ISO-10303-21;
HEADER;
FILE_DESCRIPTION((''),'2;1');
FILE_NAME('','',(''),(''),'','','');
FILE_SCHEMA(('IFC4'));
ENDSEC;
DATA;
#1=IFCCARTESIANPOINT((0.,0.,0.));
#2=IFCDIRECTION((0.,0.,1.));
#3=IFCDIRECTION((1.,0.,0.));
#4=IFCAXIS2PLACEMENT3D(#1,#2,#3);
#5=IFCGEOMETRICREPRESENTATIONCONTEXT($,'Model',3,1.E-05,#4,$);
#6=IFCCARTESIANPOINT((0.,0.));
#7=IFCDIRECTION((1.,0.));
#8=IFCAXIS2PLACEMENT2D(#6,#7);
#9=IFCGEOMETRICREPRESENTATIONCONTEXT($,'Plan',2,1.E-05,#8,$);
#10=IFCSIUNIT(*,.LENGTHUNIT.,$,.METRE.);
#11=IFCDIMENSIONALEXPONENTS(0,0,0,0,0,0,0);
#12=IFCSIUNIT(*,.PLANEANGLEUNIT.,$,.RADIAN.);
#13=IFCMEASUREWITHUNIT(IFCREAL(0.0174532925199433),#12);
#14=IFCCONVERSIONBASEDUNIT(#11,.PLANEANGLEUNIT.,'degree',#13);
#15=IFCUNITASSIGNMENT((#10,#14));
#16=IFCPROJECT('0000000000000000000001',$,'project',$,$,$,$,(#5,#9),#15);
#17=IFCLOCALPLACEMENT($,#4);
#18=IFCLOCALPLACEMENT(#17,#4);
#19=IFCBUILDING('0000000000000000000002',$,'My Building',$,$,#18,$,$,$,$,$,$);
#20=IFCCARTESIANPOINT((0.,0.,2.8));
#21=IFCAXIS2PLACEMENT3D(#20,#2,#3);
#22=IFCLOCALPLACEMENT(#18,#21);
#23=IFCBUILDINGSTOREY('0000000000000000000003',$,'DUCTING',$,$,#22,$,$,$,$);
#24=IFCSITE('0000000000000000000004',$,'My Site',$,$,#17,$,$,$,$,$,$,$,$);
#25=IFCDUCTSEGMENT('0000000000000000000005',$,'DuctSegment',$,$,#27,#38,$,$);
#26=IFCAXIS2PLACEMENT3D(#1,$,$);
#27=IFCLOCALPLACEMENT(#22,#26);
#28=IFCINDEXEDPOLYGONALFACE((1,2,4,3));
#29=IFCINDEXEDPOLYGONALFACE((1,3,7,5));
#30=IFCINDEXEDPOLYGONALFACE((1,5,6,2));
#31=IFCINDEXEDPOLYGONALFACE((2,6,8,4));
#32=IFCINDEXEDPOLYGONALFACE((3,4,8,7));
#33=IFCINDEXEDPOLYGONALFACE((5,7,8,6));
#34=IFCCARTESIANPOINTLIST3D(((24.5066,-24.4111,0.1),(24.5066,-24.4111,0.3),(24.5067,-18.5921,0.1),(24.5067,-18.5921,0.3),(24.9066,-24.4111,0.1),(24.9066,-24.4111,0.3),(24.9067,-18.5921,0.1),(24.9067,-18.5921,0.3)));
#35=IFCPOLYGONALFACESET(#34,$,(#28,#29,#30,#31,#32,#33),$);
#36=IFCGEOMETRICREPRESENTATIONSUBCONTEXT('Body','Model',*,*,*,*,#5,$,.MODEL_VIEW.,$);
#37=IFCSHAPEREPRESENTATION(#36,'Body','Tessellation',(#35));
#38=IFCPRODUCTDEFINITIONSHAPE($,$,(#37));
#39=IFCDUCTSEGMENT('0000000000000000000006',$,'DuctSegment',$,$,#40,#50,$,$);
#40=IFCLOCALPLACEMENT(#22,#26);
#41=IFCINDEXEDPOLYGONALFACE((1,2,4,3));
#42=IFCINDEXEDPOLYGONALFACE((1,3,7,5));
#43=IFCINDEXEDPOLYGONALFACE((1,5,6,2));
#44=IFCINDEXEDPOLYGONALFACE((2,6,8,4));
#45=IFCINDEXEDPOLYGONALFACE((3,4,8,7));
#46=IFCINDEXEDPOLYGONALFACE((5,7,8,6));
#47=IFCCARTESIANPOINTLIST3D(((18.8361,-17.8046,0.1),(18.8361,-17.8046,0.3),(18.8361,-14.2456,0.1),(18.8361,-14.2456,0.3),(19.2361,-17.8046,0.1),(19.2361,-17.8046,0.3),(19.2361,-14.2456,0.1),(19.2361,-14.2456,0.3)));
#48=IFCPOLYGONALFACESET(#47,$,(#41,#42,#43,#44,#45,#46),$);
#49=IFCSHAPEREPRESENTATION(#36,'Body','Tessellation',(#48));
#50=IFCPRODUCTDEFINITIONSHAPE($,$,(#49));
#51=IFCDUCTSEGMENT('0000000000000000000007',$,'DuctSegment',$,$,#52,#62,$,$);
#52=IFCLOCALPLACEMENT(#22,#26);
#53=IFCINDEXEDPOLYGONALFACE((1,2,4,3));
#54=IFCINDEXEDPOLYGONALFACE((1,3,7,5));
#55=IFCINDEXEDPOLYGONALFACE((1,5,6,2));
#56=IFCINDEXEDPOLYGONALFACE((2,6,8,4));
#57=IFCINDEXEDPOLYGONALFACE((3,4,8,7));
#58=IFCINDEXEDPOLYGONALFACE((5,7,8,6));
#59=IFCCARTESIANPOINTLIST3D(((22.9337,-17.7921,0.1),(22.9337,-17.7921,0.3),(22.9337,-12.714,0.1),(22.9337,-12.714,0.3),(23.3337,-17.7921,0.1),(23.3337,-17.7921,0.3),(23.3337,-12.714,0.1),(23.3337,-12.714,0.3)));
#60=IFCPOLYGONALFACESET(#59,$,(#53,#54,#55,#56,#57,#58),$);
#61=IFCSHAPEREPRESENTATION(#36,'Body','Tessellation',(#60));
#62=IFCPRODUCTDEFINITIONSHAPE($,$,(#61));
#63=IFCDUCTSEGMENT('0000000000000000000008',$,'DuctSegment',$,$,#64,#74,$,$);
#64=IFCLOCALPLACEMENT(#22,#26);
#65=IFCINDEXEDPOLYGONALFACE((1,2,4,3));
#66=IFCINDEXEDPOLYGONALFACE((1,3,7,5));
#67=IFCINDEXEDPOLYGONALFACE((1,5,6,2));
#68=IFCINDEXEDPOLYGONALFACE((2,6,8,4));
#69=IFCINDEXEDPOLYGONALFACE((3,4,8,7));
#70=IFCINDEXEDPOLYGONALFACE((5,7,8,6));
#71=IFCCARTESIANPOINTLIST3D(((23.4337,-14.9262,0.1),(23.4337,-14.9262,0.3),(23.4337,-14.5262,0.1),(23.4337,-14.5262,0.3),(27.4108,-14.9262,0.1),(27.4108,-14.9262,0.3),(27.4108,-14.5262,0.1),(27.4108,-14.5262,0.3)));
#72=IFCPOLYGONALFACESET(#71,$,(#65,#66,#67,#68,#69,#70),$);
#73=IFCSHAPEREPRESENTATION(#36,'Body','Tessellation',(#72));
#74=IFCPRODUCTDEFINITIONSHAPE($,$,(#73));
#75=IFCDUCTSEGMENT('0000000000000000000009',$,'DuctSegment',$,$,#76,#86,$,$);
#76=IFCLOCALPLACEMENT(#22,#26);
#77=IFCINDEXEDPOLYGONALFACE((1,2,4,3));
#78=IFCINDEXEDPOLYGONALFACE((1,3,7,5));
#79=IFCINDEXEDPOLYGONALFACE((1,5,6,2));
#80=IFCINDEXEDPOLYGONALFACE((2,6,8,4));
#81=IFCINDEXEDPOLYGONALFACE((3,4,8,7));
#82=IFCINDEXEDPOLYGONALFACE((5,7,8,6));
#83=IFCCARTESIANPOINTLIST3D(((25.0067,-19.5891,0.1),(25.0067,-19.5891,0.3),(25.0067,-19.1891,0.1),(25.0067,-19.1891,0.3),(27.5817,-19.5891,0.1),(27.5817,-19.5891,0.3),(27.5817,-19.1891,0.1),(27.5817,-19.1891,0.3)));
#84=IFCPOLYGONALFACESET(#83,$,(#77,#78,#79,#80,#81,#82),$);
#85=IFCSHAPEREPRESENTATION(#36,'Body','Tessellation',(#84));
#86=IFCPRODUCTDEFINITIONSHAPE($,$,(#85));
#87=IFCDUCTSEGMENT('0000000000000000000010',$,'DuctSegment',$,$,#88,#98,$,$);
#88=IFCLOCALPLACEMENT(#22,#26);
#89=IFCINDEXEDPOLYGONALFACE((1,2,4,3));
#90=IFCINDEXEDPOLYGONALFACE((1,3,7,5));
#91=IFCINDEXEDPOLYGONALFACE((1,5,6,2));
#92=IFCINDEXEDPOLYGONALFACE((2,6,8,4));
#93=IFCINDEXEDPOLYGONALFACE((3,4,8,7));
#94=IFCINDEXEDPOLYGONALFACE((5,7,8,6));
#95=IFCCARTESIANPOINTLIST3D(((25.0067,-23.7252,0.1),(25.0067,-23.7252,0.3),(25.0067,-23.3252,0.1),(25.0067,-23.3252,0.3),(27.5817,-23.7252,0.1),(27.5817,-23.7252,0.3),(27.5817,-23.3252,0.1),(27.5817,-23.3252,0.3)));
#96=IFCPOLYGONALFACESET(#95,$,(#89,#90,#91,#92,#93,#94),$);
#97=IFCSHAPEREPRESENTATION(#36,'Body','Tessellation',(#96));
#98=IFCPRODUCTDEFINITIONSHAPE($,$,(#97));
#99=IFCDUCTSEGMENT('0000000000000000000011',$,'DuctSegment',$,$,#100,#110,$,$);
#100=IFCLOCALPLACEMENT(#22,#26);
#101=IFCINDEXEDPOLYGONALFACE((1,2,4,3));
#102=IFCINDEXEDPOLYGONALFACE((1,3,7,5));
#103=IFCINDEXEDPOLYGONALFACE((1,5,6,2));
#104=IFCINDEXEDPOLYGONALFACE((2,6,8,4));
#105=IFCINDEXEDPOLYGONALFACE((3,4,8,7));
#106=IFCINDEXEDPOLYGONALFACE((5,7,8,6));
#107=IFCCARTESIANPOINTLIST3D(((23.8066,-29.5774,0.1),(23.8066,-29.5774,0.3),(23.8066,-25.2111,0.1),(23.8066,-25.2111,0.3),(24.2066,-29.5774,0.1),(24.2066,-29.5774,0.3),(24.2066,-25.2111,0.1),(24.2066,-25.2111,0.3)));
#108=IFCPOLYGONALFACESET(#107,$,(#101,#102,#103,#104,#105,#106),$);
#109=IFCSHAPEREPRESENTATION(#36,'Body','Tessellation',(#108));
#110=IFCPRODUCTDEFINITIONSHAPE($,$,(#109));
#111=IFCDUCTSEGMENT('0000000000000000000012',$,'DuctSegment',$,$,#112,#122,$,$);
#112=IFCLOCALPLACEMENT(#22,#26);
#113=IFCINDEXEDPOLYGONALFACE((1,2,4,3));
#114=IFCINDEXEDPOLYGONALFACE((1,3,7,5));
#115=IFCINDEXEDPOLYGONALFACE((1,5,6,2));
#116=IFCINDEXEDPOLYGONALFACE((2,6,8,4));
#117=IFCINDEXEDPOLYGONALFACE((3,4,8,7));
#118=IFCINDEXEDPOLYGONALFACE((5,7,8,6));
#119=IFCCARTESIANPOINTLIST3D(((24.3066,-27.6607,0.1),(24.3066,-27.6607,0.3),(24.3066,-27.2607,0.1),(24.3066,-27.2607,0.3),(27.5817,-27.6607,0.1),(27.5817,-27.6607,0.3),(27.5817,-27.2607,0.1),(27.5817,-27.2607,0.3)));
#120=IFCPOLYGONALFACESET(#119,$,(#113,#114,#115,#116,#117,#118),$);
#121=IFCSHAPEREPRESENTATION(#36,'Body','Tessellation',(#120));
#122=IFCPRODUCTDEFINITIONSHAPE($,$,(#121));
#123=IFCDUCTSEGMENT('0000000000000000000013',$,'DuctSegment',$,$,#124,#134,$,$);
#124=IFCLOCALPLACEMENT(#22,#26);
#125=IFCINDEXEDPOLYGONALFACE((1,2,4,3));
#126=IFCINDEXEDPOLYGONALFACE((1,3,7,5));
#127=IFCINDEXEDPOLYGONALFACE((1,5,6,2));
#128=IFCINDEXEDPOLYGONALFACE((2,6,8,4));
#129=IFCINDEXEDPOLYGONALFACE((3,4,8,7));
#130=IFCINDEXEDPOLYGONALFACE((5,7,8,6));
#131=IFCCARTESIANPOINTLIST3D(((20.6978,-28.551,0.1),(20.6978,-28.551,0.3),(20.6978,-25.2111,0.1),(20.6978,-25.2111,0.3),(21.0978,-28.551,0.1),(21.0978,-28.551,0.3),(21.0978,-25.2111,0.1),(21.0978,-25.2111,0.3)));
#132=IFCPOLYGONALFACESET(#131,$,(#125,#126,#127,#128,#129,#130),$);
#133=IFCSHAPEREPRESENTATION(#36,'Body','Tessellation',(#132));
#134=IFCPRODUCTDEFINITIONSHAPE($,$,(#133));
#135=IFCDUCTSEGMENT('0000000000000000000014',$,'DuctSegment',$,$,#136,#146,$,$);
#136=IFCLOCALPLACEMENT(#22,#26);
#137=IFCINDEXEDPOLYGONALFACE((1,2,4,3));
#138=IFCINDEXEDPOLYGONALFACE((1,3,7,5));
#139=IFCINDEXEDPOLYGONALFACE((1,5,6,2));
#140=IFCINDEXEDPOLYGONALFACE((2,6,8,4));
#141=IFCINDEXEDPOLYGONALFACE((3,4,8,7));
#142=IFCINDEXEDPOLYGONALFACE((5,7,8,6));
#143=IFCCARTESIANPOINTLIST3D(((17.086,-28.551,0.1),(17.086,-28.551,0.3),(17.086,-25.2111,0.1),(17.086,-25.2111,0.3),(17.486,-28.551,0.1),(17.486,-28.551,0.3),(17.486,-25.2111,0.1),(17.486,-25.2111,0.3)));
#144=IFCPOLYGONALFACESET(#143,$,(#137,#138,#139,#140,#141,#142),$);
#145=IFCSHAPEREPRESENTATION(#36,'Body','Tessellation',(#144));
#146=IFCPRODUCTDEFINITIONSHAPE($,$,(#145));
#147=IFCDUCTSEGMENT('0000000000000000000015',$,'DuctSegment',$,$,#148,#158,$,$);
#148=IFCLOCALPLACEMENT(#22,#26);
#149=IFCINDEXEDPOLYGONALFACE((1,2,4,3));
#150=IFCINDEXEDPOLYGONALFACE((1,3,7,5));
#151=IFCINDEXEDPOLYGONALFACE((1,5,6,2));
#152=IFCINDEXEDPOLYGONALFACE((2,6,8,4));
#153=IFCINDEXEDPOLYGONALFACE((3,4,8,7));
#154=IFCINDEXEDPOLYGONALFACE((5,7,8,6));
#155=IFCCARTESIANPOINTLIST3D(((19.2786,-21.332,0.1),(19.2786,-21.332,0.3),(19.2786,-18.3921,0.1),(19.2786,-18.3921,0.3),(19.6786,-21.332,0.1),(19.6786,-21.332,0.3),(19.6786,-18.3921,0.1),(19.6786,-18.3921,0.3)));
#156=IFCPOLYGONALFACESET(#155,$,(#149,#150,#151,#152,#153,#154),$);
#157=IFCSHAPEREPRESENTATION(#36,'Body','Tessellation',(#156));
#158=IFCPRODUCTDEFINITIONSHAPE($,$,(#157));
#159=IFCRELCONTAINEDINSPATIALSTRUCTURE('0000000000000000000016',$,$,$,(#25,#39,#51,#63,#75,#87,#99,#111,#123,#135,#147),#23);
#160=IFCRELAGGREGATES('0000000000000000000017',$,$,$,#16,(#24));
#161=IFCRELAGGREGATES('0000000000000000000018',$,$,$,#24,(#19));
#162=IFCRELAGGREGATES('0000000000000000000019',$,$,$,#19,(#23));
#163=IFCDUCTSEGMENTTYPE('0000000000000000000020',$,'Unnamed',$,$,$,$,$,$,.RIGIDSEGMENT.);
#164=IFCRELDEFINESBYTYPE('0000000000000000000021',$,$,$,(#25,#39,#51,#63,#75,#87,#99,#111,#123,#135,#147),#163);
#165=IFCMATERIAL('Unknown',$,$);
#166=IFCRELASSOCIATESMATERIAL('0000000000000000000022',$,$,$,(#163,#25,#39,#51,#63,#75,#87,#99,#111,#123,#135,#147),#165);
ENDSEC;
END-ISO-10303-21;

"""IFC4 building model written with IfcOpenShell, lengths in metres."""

from ifc_helpers import new_model, entity, si_unit, converted_unit, frame, origin_with_axes, origin_2d_with_axis, place, context, subcontext, project, spatial, rectangle, extrude, material, material_profile, profile_set, profile_usage, type_object, element, save


model = new_model("IFC4")

# Units and contexts
model_context = context("Model", 3, precision=1e-05, world=origin_with_axes())
plan_context = context("Plan", 2, precision=1e-05, world=origin_2d_with_axis())
body_context = subcontext(model_context, "Body", "Model", "MODEL_VIEW")
ifc_project = project(units=[si_unit("LENGTHUNIT", "METRE"), converted_unit("PLANEANGLEUNIT", "degree", entity("IfcReal", 0.0174532925199433), si_unit("PLANEANGLEUNIT", "RADIAN"), dimensions=[0, 0, 0, 0, 0, 0, 0])], contexts=[model_context, plan_context])

# Site, building, storey
site_placement = place(None, origin_with_axes())
site = spatial("IfcSite", under=ifc_project, at=site_placement, Name="My Site")
building_placement = place(site_placement, origin_with_axes())
building = spatial("IfcBuilding", under=site, at=building_placement, Name="My Building")
storey_placement = place(building_placement, frame((0.0, 0.0, 2.8), z_axis=(0.0, 0.0, 1.0), x_axis=(1.0, 0.0, 0.0)))
storey = spatial("IfcBuildingStorey", under=building, at=storey_placement, Name="DUCTING")

# Duct segments
ifc_material = material(Name="Unknown")
ifc_material_profile_1 = material_profile(ifc_material, rectangle(XDim=0.4, YDim=0.2))
ifc_profile_set_1 = profile_set([ifc_material_profile_1])
ifc_profile_usage_1 = profile_usage(ifc_profile_set_1, cardinal=5)
duct_segment_type = type_object("IfcDuctSegmentType", Name="Unnamed", PredefinedType="RIGIDSEGMENT", material=ifc_profile_set_1)
duct_segment_1_placement = place(storey_placement, frame((24.7067, -18.5921, 0.2), z_axis=(-0.00001, -1.0, 0.000001), x_axis=(1.0, -0.00001, 0.0)))
element("IfcDuctSegment", 1, at=duct_segment_1_placement, inside=storey, type_object=duct_segment_type, material=ifc_profile_usage_1, Name="DuctSegment", context=body_context, shape_type="SweptSolid", body=[
    extrude(rectangle(XDim=0.4, YDim=0.2), origin_with_axes(), (0.0, 0.0, 1.0), 5.819),
])
ifc_profile_usage_2 = profile_usage(ifc_profile_set_1, cardinal=5)
duct_segment_2_placement = place(storey_placement, frame((19.0361, -17.8046, 0.2), z_axis=(0.0, 1.0, 0.0), x_axis=(-1.0, 0.0, 0.0)))
element("IfcDuctSegment", 2, at=duct_segment_2_placement, inside=storey, type_object=duct_segment_type, material=ifc_profile_usage_2, Name="DuctSegment", context=body_context, shape_type="SweptSolid", body=[
    extrude(rectangle(XDim=0.4, YDim=0.2), origin_with_axes(), (0.0, 0.0, 1.0), 3.5591),
])
ifc_profile_usage_3 = profile_usage(ifc_profile_set_1, cardinal=5)
duct_segment_3_placement = place(storey_placement, frame((23.1337, -17.7921, 0.2), z_axis=(0.0, 1.0, 0.0), x_axis=(-1.0, 0.0, 0.0)))
element("IfcDuctSegment", 3, at=duct_segment_3_placement, inside=storey, type_object=duct_segment_type, material=ifc_profile_usage_3, Name="DuctSegment", context=body_context, shape_type="SweptSolid", body=[
    extrude(rectangle(XDim=0.4, YDim=0.2), origin_with_axes(), (0.0, 0.0, 1.0), 5.0781),
])
ifc_profile_usage_4 = profile_usage(ifc_profile_set_1, cardinal=5)
duct_segment_4_placement = place(storey_placement, frame((23.4337, -14.7262, 0.2), z_axis=(1.0, 0.0, 0.0), x_axis=(0.0, 1.0, 0.0)))
element("IfcDuctSegment", 4, at=duct_segment_4_placement, inside=storey, type_object=duct_segment_type, material=ifc_profile_usage_4, Name="DuctSegment", context=body_context, shape_type="SweptSolid", body=[
    extrude(rectangle(XDim=0.4, YDim=0.2), origin_with_axes(), (0.0, 0.0, 1.0), 3.9771),
])
ifc_profile_usage_5 = profile_usage(ifc_profile_set_1, cardinal=5)
duct_segment_5_placement = place(storey_placement, frame((25.0067, -19.3891, 0.2), z_axis=(1.0, 0.0, 0.0), x_axis=(0.0, 1.0, 0.0)))
element("IfcDuctSegment", 5, at=duct_segment_5_placement, inside=storey, type_object=duct_segment_type, material=ifc_profile_usage_5, Name="DuctSegment", context=body_context, shape_type="SweptSolid", body=[
    extrude(rectangle(XDim=0.4, YDim=0.2), origin_with_axes(), (0.0, 0.0, 1.0), 2.575),
])
ifc_profile_usage_6 = profile_usage(ifc_profile_set_1, cardinal=5)
duct_segment_6_placement = place(storey_placement, frame((25.0067, -23.5252, 0.2), z_axis=(1.0, 0.0, 0.0), x_axis=(0.0, 1.0, 0.0)))
element("IfcDuctSegment", 6, at=duct_segment_6_placement, inside=storey, type_object=duct_segment_type, material=ifc_profile_usage_6, Name="DuctSegment", context=body_context, shape_type="SweptSolid", body=[
    extrude(rectangle(XDim=0.4, YDim=0.2), origin_with_axes(), (0.0, 0.0, 1.0), 2.575),
])
ifc_profile_usage_7 = profile_usage(ifc_profile_set_1, cardinal=5)
duct_segment_7_placement = place(storey_placement, frame((24.0066, -25.2111, 0.2), z_axis=(0.0, -1.0, 0.0), x_axis=(1.0, 0.0, 0.0)))
element("IfcDuctSegment", 7, at=duct_segment_7_placement, inside=storey, type_object=duct_segment_type, material=ifc_profile_usage_7, Name="DuctSegment", context=body_context, shape_type="SweptSolid", body=[
    extrude(rectangle(XDim=0.4, YDim=0.2), origin_with_axes(), (0.0, 0.0, 1.0), 4.3664),
])
ifc_profile_usage_8 = profile_usage(ifc_profile_set_1, cardinal=5)
duct_segment_8_placement = place(storey_placement, frame((24.3066, -27.4607, 0.2), z_axis=(1.0, 0.0, 0.0), x_axis=(0.0, 1.0, 0.0)))
element("IfcDuctSegment", 8, at=duct_segment_8_placement, inside=storey, type_object=duct_segment_type, material=ifc_profile_usage_8, Name="DuctSegment", context=body_context, shape_type="SweptSolid", body=[
    extrude(rectangle(XDim=0.4, YDim=0.2), origin_with_axes(), (0.0, 0.0, 1.0), 3.2751),
])
ifc_profile_usage_9 = profile_usage(ifc_profile_set_1, cardinal=5)
duct_segment_9_placement = place(storey_placement, frame((20.8978, -25.2111, 0.2), z_axis=(0.0, -1.0, 0.0), x_axis=(1.0, 0.0, 0.0)))
element("IfcDuctSegment", 9, at=duct_segment_9_placement, inside=storey, type_object=duct_segment_type, material=ifc_profile_usage_9, Name="DuctSegment", context=body_context, shape_type="SweptSolid", body=[
    extrude(rectangle(XDim=0.4, YDim=0.2), origin_with_axes(), (0.0, 0.0, 1.0), 3.3399),
])
ifc_profile_usage_10 = profile_usage(ifc_profile_set_1, cardinal=5)
duct_segment_10_placement = place(storey_placement, frame((17.286, -25.2111, 0.2), z_axis=(0.0, -1.0, 0.0), x_axis=(1.0, 0.0, 0.0)))
element("IfcDuctSegment", 10, at=duct_segment_10_placement, inside=storey, type_object=duct_segment_type, material=ifc_profile_usage_10, Name="DuctSegment", context=body_context, shape_type="SweptSolid", body=[
    extrude(rectangle(XDim=0.4, YDim=0.2), origin_with_axes(), (0.0, 0.0, 1.0), 3.3399),
])
ifc_profile_usage_11 = profile_usage(ifc_profile_set_1, cardinal=5)
duct_segment_11_placement = place(storey_placement, frame((19.4786, -18.3921, 0.2), z_axis=(0.0, -1.0, 0.0), x_axis=(1.0, 0.0, 0.0)))
element("IfcDuctSegment", 11, at=duct_segment_11_placement, inside=storey, type_object=duct_segment_type, material=ifc_profile_usage_11, Name="DuctSegment", context=body_context, shape_type="SweptSolid", body=[
    extrude(rectangle(XDim=0.4, YDim=0.2), origin_with_axes(), (0.0, 0.0, 1.0), 2.9399),
])

save(model, "model.ifc")
